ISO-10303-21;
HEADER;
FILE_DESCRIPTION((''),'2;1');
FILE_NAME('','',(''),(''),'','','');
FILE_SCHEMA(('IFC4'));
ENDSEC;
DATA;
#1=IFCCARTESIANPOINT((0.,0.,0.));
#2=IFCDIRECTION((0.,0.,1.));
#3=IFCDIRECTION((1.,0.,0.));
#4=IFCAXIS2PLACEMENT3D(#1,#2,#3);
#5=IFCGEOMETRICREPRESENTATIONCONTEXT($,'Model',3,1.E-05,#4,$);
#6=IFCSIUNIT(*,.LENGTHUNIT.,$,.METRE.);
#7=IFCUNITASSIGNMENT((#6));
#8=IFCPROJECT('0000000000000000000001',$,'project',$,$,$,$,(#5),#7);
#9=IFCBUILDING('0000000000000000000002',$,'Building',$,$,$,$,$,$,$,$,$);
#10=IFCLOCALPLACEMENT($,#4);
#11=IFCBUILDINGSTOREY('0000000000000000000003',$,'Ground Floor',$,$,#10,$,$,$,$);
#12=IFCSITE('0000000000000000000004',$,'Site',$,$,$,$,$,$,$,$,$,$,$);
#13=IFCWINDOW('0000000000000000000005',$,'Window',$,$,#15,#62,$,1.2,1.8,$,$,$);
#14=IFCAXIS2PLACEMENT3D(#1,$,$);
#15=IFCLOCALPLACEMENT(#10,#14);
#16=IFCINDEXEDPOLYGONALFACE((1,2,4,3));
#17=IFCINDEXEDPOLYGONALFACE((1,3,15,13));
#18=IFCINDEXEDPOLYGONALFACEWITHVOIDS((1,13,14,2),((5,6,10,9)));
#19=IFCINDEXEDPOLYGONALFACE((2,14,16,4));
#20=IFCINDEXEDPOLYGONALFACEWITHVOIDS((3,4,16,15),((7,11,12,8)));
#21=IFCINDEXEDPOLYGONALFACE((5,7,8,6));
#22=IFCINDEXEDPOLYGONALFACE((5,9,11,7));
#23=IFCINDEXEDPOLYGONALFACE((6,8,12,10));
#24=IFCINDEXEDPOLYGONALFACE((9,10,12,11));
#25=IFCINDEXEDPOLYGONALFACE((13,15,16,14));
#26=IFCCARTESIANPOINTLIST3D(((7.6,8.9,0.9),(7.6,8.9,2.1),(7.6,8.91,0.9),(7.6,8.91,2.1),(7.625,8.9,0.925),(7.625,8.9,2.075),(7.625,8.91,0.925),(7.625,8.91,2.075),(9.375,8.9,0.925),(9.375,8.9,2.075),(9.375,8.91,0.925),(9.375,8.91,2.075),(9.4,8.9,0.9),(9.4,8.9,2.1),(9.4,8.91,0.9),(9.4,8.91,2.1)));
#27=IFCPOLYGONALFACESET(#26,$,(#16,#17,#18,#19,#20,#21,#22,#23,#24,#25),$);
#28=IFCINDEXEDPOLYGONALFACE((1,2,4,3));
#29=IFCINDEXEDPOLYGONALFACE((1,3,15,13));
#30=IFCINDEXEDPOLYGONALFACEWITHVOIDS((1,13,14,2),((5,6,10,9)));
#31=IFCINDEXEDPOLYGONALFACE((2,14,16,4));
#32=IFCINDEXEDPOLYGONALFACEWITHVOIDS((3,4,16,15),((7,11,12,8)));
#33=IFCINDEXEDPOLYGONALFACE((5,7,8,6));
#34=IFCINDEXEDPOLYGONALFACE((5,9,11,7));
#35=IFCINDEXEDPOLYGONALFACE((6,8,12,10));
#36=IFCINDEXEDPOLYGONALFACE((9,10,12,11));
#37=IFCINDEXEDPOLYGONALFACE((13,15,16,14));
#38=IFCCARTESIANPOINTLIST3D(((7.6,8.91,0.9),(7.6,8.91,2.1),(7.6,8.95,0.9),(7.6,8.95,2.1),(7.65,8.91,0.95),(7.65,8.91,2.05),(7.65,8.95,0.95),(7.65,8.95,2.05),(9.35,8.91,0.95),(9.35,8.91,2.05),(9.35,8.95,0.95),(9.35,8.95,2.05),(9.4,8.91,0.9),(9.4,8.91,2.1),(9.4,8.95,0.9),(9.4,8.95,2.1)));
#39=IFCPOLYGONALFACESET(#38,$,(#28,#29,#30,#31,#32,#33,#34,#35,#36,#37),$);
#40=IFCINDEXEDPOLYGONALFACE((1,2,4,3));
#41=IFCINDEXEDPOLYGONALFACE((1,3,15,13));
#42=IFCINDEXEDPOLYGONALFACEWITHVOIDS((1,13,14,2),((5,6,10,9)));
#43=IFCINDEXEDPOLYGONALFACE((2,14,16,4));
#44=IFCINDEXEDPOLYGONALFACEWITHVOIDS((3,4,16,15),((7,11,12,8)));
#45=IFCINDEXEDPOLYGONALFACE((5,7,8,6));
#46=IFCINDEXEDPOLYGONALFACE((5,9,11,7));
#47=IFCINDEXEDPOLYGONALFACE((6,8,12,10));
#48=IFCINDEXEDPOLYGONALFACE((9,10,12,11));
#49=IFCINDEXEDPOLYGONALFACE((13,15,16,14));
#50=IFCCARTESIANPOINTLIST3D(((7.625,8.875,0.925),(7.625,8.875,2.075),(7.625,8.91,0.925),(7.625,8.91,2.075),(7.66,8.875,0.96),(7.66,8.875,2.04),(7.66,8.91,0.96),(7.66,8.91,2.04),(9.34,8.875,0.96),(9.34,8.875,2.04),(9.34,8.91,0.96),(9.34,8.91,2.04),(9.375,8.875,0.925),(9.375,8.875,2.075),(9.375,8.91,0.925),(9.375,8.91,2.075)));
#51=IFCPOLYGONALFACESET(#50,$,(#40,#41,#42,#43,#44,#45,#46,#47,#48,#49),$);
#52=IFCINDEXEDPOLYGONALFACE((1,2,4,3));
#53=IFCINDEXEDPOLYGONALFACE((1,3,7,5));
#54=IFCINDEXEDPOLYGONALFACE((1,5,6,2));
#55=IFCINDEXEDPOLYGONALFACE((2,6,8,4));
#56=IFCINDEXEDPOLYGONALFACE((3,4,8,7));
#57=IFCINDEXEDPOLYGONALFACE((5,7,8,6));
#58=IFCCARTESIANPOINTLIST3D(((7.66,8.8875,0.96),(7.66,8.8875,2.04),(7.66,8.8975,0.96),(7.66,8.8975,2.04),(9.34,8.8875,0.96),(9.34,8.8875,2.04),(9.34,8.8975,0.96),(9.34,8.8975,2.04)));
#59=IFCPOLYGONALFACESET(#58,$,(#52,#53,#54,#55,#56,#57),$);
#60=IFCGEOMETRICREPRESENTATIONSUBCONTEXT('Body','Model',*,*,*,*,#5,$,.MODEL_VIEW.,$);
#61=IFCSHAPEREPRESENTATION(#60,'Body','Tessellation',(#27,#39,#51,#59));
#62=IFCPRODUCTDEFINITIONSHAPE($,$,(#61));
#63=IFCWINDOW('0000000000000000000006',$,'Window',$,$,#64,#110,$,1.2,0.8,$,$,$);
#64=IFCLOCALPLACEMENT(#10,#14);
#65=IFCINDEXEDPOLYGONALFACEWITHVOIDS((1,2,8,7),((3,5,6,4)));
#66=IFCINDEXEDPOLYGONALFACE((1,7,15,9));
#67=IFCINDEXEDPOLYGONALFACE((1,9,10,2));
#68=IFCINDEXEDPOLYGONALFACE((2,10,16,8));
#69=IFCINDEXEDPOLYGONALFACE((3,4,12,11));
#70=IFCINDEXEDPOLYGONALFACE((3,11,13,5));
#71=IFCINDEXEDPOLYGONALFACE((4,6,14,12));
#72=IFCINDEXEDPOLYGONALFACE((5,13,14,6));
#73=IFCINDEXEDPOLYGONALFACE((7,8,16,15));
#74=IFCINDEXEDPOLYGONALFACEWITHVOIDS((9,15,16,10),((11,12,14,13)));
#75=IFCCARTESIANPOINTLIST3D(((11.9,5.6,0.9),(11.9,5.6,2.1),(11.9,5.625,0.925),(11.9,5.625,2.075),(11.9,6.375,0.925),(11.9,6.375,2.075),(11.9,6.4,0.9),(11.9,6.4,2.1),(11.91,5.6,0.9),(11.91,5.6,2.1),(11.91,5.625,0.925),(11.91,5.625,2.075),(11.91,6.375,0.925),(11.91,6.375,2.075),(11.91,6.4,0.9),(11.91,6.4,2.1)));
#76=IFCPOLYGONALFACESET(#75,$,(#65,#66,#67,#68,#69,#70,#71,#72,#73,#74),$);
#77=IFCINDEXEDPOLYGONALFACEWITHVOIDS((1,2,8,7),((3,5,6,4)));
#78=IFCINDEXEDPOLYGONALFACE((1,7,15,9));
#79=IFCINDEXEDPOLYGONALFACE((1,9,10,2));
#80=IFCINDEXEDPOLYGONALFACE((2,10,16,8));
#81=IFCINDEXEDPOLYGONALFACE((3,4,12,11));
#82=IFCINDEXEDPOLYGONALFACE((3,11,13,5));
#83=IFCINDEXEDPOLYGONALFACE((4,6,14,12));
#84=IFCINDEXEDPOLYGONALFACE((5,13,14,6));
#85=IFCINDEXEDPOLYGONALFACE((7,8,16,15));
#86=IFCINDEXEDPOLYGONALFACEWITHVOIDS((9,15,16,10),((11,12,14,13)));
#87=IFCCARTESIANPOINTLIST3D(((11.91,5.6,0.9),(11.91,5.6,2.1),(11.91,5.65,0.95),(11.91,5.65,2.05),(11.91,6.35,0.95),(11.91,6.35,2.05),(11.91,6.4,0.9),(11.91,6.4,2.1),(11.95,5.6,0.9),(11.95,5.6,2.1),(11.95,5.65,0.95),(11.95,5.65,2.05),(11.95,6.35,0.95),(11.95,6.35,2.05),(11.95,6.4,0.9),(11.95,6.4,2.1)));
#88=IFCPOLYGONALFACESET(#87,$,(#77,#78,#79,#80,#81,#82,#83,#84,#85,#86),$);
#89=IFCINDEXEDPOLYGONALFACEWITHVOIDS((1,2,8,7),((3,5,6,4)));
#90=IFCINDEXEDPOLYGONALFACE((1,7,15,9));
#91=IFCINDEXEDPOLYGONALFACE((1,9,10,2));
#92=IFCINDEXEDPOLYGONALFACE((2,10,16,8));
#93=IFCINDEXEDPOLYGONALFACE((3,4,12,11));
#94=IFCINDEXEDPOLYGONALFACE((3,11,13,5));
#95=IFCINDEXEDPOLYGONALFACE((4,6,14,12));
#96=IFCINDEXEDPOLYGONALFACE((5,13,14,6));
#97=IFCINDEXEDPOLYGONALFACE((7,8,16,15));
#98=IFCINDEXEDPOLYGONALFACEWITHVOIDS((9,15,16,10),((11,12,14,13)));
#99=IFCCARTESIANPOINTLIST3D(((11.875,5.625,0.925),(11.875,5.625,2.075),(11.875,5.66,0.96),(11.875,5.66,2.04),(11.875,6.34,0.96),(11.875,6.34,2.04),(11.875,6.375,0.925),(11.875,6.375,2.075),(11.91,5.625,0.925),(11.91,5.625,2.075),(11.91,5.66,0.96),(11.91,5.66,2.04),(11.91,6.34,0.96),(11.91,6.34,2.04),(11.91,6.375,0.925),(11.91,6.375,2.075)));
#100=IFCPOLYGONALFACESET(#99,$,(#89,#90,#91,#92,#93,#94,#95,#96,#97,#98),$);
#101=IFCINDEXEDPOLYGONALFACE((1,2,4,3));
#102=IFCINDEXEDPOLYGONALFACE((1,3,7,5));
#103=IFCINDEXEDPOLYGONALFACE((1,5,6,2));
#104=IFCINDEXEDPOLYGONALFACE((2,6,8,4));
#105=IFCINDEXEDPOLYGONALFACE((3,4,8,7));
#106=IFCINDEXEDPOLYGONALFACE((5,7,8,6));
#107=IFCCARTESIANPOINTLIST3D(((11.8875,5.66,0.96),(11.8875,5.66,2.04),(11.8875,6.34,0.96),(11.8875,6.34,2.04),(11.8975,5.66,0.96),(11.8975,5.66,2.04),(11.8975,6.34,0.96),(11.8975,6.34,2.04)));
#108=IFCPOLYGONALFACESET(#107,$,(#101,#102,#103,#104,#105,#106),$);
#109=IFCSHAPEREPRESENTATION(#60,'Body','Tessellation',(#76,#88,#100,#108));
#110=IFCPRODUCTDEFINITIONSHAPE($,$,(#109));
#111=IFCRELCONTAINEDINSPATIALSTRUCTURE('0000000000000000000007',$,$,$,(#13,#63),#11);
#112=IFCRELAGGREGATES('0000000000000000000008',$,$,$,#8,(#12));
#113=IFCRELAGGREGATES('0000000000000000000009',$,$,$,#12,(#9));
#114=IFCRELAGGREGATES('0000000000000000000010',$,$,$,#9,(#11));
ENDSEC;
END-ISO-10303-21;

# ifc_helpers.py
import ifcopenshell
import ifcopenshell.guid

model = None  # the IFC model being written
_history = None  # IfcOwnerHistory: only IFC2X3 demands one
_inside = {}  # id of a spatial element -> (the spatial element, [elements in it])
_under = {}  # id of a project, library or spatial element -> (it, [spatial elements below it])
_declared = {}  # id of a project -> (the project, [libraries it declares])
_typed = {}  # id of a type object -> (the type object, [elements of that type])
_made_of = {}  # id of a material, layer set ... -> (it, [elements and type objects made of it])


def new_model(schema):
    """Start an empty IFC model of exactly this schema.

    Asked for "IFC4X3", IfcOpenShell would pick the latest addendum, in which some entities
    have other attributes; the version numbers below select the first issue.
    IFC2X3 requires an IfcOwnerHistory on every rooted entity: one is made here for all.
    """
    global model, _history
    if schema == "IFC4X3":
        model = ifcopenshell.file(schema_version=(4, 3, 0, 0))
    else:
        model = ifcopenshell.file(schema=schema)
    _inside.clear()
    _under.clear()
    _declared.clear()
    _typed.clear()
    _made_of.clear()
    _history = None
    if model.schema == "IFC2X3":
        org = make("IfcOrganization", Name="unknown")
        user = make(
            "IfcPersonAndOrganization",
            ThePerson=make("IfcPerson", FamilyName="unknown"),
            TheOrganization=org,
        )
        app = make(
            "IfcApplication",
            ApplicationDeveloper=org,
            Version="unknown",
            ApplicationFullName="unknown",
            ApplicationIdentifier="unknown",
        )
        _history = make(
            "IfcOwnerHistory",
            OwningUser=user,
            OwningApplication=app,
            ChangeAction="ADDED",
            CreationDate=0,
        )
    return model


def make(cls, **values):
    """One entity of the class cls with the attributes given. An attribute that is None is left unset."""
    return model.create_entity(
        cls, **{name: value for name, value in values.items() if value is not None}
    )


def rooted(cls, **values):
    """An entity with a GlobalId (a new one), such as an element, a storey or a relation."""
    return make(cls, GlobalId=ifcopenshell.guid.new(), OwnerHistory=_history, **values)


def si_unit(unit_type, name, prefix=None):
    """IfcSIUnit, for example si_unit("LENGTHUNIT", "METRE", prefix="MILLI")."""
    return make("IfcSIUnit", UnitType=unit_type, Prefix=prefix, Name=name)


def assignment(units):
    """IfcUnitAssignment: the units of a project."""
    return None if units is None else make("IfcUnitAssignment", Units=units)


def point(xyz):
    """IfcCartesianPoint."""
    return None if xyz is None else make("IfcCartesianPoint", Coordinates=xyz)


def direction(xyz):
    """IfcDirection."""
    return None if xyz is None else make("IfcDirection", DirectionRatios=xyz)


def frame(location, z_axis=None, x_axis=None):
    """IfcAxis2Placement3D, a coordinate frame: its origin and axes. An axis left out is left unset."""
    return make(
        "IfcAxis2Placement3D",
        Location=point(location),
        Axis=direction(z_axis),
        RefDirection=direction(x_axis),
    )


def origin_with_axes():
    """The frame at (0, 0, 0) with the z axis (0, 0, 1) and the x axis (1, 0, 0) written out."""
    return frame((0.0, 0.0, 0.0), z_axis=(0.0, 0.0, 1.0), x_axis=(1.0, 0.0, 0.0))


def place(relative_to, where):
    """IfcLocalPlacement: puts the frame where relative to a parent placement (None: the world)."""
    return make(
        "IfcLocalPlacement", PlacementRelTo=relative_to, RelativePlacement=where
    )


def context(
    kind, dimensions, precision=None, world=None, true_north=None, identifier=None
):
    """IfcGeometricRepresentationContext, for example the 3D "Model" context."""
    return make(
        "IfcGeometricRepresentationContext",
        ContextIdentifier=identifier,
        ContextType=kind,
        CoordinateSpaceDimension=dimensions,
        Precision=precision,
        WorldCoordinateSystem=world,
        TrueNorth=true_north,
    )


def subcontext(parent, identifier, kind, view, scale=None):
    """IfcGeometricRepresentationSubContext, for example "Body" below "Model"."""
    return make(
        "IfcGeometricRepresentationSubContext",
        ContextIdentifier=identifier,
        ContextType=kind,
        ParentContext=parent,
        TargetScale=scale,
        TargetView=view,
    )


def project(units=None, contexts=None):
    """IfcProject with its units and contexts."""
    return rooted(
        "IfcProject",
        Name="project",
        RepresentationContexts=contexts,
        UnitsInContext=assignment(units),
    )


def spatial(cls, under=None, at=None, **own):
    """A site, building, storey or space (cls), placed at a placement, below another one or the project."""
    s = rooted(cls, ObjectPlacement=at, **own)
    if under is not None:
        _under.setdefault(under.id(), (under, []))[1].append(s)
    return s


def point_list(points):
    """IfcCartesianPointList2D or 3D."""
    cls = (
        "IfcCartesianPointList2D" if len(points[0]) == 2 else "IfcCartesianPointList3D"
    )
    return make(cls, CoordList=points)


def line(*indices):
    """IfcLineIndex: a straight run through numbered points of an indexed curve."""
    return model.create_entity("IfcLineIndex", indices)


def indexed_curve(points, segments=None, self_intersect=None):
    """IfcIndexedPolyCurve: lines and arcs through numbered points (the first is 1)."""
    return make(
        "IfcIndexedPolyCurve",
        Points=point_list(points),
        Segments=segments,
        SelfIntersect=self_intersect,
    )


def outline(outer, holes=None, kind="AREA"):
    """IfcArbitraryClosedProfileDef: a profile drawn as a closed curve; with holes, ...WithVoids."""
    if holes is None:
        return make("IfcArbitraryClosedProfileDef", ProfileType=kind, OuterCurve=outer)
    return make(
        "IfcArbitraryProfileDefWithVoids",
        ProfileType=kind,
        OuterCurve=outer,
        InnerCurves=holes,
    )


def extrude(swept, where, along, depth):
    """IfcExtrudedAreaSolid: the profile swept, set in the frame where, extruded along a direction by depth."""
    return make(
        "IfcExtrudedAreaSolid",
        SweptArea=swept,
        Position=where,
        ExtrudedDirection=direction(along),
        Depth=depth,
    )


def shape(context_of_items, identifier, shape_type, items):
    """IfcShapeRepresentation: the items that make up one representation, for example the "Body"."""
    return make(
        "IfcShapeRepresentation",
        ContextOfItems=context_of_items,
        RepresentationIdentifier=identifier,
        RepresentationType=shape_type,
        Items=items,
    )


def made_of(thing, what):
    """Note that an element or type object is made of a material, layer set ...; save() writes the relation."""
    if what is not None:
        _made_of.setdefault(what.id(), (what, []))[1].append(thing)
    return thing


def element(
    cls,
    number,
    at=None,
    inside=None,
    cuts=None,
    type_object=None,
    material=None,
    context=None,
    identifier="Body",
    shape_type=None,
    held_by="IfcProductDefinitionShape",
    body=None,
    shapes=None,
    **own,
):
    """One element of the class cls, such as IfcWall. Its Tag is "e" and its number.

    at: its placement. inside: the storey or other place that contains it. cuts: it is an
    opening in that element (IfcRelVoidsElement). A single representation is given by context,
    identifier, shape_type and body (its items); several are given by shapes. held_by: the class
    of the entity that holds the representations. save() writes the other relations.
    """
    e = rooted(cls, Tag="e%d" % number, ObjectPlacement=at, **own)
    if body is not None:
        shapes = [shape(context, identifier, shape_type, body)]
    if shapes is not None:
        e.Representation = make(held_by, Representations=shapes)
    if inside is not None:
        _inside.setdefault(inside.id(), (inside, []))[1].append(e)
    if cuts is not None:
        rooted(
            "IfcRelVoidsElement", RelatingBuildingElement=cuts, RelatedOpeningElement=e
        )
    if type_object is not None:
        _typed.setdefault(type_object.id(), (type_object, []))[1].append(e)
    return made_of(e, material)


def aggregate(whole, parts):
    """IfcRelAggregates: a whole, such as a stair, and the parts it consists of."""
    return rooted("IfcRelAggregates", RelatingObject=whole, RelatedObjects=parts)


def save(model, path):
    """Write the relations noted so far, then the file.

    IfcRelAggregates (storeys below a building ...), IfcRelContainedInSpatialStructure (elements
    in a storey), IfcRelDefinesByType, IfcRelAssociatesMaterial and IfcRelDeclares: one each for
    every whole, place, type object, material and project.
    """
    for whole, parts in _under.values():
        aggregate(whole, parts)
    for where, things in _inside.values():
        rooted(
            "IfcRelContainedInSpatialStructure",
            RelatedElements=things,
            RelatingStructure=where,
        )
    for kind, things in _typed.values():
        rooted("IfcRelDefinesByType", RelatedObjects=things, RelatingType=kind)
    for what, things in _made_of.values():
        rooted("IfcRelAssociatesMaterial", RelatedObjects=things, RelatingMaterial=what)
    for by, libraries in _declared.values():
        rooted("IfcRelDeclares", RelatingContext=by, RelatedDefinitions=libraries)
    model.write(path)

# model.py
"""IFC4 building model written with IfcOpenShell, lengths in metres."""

from ifc_helpers import new_model, si_unit, frame, origin_with_axes, place, context, subcontext, project, spatial, line, indexed_curve, outline, extrude, element, save


model = new_model("IFC4")

# Units and contexts
model_context = context("Model", 3, precision=1e-05, world=origin_with_axes())
body_context = subcontext(model_context, "Body", "Model", "MODEL_VIEW")
ifc_project = project(units=[si_unit("LENGTHUNIT", "METRE")], contexts=[model_context])

# Site, building, storey
site = spatial("IfcSite", under=ifc_project, Name="Site")
building = spatial("IfcBuilding", under=site, Name="Building")
storey_placement = place(None, origin_with_axes())
storey = spatial("IfcBuildingStorey", under=building, at=storey_placement, Name="Ground Floor")

# Windows
window_1_placement = place(storey_placement, frame((9.4, 9.0, 0.9), z_axis=(0.0, 0.0, 1.0), x_axis=(-1.0, 0.0, 0.0)))
element("IfcWindow", 1, at=window_1_placement, inside=storey, Name="Window", OverallHeight=1.2, OverallWidth=1.8, context=body_context, shape_type="SweptSolid", body=[
    extrude(outline(indexed_curve([(0.0, 0.0), (1.8, 0.0), (1.8, 1.2), (0.0, 1.2)], segments=[line(1, 2, 3, 4, 1)]), holes=[indexed_curve([(0.025, 0.025), (1.775, 0.025), (1.775, 1.175), (0.025, 1.175)], segments=[line(1, 2, 3, 4, 1)])]), frame((0.0, 0.09, 0.0), z_axis=(0.0, -1.0, 0.0), x_axis=(1.0, 0.0, 0.0)), (0.0, 0.0, -1.0), 0.01),
    extrude(outline(indexed_curve([(0.0, 0.0), (1.8, 0.0), (1.8, 1.2), (0.0, 1.2)], segments=[line(1, 2, 3, 4, 1)]), holes=[indexed_curve([(0.05, 0.05), (1.75, 0.05), (1.75, 1.15), (0.05, 1.15)], segments=[line(1, 2, 3, 4, 1)])]), frame((0.0, 0.05, 0.0), z_axis=(0.0, -1.0, 0.0), x_axis=(1.0, 0.0, 0.0)), (0.0, 0.0, -1.0), 0.04),
    extrude(outline(indexed_curve([(0.0, 0.0), (1.75, 0.0), (1.75, 1.15), (0.0, 1.15)], segments=[line(1, 2, 3, 4, 1)]), holes=[indexed_curve([(0.035, 0.035), (1.715, 0.035), (1.715, 1.115), (0.035, 1.115)], segments=[line(1, 2, 3, 4, 1)])]), frame((0.025, 0.09, 0.025), z_axis=(0.0, -1.0, 0.0), x_axis=(1.0, 0.0, 0.0)), (0.0, 0.0, -1.0), 0.035),
    extrude(outline(indexed_curve([(0.035, 0.035), (1.715, 0.035), (1.715, 1.115), (0.035, 1.115)], segments=[line(1, 2, 3, 4, 1)])), frame((0.025, 0.1025, 0.025), z_axis=(0.0, -1.0, 0.0), x_axis=(1.0, 0.0, 0.0)), (0.0, 0.0, -1.0), 0.01),
])
window_2_placement = place(storey_placement, frame((12.0, 5.6, 0.9), z_axis=(0.0, 0.0, 1.0), x_axis=(0.0, 1.0, 0.0)))
element("IfcWindow", 2, at=window_2_placement, inside=storey, Name="Window", OverallHeight=1.2, OverallWidth=0.8, context=body_context, shape_type="SweptSolid", body=[
    extrude(outline(indexed_curve([(0.0, 0.0), (0.8, 0.0), (0.8, 1.2), (0.0, 1.2)], segments=[line(1, 2, 3, 4, 1)]), holes=[indexed_curve([(0.025, 0.025), (0.775, 0.025), (0.775, 1.175), (0.025, 1.175)], segments=[line(1, 2, 3, 4, 1)])]), frame((0.0, 0.09, 0.0), z_axis=(0.0, -1.0, 0.0), x_axis=(1.0, 0.0, 0.0)), (0.0, 0.0, -1.0), 0.01),
    extrude(outline(indexed_curve([(0.0, 0.0), (0.8, 0.0), (0.8, 1.2), (0.0, 1.2)], segments=[line(1, 2, 3, 4, 1)]), holes=[indexed_curve([(0.05, 0.05), (0.75, 0.05), (0.75, 1.15), (0.05, 1.15)], segments=[line(1, 2, 3, 4, 1)])]), frame((0.0, 0.05, 0.0), z_axis=(0.0, -1.0, 0.0), x_axis=(1.0, 0.0, 0.0)), (0.0, 0.0, -1.0), 0.04),
    extrude(outline(indexed_curve([(0.0, 0.0), (0.75, 0.0), (0.75, 1.15), (0.0, 1.15)], segments=[line(1, 2, 3, 4, 1)]), holes=[indexed_curve([(0.035, 0.035), (0.715, 0.035), (0.715, 1.115), (0.035, 1.115)], segments=[line(1, 2, 3, 4, 1)])]), frame((0.025, 0.09, 0.025), z_axis=(0.0, -1.0, 0.0), x_axis=(1.0, 0.0, 0.0)), (0.0, 0.0, -1.0), 0.035),
    extrude(outline(indexed_curve([(0.035, 0.035), (0.715, 0.035), (0.715, 1.115), (0.035, 1.115)], segments=[line(1, 2, 3, 4, 1)])), frame((0.025, 0.1025, 0.025), z_axis=(0.0, -1.0, 0.0), x_axis=(1.0, 0.0, 0.0)), (0.0, 0.0, -1.0), 0.01),
])

save(model, "model.ifc")
